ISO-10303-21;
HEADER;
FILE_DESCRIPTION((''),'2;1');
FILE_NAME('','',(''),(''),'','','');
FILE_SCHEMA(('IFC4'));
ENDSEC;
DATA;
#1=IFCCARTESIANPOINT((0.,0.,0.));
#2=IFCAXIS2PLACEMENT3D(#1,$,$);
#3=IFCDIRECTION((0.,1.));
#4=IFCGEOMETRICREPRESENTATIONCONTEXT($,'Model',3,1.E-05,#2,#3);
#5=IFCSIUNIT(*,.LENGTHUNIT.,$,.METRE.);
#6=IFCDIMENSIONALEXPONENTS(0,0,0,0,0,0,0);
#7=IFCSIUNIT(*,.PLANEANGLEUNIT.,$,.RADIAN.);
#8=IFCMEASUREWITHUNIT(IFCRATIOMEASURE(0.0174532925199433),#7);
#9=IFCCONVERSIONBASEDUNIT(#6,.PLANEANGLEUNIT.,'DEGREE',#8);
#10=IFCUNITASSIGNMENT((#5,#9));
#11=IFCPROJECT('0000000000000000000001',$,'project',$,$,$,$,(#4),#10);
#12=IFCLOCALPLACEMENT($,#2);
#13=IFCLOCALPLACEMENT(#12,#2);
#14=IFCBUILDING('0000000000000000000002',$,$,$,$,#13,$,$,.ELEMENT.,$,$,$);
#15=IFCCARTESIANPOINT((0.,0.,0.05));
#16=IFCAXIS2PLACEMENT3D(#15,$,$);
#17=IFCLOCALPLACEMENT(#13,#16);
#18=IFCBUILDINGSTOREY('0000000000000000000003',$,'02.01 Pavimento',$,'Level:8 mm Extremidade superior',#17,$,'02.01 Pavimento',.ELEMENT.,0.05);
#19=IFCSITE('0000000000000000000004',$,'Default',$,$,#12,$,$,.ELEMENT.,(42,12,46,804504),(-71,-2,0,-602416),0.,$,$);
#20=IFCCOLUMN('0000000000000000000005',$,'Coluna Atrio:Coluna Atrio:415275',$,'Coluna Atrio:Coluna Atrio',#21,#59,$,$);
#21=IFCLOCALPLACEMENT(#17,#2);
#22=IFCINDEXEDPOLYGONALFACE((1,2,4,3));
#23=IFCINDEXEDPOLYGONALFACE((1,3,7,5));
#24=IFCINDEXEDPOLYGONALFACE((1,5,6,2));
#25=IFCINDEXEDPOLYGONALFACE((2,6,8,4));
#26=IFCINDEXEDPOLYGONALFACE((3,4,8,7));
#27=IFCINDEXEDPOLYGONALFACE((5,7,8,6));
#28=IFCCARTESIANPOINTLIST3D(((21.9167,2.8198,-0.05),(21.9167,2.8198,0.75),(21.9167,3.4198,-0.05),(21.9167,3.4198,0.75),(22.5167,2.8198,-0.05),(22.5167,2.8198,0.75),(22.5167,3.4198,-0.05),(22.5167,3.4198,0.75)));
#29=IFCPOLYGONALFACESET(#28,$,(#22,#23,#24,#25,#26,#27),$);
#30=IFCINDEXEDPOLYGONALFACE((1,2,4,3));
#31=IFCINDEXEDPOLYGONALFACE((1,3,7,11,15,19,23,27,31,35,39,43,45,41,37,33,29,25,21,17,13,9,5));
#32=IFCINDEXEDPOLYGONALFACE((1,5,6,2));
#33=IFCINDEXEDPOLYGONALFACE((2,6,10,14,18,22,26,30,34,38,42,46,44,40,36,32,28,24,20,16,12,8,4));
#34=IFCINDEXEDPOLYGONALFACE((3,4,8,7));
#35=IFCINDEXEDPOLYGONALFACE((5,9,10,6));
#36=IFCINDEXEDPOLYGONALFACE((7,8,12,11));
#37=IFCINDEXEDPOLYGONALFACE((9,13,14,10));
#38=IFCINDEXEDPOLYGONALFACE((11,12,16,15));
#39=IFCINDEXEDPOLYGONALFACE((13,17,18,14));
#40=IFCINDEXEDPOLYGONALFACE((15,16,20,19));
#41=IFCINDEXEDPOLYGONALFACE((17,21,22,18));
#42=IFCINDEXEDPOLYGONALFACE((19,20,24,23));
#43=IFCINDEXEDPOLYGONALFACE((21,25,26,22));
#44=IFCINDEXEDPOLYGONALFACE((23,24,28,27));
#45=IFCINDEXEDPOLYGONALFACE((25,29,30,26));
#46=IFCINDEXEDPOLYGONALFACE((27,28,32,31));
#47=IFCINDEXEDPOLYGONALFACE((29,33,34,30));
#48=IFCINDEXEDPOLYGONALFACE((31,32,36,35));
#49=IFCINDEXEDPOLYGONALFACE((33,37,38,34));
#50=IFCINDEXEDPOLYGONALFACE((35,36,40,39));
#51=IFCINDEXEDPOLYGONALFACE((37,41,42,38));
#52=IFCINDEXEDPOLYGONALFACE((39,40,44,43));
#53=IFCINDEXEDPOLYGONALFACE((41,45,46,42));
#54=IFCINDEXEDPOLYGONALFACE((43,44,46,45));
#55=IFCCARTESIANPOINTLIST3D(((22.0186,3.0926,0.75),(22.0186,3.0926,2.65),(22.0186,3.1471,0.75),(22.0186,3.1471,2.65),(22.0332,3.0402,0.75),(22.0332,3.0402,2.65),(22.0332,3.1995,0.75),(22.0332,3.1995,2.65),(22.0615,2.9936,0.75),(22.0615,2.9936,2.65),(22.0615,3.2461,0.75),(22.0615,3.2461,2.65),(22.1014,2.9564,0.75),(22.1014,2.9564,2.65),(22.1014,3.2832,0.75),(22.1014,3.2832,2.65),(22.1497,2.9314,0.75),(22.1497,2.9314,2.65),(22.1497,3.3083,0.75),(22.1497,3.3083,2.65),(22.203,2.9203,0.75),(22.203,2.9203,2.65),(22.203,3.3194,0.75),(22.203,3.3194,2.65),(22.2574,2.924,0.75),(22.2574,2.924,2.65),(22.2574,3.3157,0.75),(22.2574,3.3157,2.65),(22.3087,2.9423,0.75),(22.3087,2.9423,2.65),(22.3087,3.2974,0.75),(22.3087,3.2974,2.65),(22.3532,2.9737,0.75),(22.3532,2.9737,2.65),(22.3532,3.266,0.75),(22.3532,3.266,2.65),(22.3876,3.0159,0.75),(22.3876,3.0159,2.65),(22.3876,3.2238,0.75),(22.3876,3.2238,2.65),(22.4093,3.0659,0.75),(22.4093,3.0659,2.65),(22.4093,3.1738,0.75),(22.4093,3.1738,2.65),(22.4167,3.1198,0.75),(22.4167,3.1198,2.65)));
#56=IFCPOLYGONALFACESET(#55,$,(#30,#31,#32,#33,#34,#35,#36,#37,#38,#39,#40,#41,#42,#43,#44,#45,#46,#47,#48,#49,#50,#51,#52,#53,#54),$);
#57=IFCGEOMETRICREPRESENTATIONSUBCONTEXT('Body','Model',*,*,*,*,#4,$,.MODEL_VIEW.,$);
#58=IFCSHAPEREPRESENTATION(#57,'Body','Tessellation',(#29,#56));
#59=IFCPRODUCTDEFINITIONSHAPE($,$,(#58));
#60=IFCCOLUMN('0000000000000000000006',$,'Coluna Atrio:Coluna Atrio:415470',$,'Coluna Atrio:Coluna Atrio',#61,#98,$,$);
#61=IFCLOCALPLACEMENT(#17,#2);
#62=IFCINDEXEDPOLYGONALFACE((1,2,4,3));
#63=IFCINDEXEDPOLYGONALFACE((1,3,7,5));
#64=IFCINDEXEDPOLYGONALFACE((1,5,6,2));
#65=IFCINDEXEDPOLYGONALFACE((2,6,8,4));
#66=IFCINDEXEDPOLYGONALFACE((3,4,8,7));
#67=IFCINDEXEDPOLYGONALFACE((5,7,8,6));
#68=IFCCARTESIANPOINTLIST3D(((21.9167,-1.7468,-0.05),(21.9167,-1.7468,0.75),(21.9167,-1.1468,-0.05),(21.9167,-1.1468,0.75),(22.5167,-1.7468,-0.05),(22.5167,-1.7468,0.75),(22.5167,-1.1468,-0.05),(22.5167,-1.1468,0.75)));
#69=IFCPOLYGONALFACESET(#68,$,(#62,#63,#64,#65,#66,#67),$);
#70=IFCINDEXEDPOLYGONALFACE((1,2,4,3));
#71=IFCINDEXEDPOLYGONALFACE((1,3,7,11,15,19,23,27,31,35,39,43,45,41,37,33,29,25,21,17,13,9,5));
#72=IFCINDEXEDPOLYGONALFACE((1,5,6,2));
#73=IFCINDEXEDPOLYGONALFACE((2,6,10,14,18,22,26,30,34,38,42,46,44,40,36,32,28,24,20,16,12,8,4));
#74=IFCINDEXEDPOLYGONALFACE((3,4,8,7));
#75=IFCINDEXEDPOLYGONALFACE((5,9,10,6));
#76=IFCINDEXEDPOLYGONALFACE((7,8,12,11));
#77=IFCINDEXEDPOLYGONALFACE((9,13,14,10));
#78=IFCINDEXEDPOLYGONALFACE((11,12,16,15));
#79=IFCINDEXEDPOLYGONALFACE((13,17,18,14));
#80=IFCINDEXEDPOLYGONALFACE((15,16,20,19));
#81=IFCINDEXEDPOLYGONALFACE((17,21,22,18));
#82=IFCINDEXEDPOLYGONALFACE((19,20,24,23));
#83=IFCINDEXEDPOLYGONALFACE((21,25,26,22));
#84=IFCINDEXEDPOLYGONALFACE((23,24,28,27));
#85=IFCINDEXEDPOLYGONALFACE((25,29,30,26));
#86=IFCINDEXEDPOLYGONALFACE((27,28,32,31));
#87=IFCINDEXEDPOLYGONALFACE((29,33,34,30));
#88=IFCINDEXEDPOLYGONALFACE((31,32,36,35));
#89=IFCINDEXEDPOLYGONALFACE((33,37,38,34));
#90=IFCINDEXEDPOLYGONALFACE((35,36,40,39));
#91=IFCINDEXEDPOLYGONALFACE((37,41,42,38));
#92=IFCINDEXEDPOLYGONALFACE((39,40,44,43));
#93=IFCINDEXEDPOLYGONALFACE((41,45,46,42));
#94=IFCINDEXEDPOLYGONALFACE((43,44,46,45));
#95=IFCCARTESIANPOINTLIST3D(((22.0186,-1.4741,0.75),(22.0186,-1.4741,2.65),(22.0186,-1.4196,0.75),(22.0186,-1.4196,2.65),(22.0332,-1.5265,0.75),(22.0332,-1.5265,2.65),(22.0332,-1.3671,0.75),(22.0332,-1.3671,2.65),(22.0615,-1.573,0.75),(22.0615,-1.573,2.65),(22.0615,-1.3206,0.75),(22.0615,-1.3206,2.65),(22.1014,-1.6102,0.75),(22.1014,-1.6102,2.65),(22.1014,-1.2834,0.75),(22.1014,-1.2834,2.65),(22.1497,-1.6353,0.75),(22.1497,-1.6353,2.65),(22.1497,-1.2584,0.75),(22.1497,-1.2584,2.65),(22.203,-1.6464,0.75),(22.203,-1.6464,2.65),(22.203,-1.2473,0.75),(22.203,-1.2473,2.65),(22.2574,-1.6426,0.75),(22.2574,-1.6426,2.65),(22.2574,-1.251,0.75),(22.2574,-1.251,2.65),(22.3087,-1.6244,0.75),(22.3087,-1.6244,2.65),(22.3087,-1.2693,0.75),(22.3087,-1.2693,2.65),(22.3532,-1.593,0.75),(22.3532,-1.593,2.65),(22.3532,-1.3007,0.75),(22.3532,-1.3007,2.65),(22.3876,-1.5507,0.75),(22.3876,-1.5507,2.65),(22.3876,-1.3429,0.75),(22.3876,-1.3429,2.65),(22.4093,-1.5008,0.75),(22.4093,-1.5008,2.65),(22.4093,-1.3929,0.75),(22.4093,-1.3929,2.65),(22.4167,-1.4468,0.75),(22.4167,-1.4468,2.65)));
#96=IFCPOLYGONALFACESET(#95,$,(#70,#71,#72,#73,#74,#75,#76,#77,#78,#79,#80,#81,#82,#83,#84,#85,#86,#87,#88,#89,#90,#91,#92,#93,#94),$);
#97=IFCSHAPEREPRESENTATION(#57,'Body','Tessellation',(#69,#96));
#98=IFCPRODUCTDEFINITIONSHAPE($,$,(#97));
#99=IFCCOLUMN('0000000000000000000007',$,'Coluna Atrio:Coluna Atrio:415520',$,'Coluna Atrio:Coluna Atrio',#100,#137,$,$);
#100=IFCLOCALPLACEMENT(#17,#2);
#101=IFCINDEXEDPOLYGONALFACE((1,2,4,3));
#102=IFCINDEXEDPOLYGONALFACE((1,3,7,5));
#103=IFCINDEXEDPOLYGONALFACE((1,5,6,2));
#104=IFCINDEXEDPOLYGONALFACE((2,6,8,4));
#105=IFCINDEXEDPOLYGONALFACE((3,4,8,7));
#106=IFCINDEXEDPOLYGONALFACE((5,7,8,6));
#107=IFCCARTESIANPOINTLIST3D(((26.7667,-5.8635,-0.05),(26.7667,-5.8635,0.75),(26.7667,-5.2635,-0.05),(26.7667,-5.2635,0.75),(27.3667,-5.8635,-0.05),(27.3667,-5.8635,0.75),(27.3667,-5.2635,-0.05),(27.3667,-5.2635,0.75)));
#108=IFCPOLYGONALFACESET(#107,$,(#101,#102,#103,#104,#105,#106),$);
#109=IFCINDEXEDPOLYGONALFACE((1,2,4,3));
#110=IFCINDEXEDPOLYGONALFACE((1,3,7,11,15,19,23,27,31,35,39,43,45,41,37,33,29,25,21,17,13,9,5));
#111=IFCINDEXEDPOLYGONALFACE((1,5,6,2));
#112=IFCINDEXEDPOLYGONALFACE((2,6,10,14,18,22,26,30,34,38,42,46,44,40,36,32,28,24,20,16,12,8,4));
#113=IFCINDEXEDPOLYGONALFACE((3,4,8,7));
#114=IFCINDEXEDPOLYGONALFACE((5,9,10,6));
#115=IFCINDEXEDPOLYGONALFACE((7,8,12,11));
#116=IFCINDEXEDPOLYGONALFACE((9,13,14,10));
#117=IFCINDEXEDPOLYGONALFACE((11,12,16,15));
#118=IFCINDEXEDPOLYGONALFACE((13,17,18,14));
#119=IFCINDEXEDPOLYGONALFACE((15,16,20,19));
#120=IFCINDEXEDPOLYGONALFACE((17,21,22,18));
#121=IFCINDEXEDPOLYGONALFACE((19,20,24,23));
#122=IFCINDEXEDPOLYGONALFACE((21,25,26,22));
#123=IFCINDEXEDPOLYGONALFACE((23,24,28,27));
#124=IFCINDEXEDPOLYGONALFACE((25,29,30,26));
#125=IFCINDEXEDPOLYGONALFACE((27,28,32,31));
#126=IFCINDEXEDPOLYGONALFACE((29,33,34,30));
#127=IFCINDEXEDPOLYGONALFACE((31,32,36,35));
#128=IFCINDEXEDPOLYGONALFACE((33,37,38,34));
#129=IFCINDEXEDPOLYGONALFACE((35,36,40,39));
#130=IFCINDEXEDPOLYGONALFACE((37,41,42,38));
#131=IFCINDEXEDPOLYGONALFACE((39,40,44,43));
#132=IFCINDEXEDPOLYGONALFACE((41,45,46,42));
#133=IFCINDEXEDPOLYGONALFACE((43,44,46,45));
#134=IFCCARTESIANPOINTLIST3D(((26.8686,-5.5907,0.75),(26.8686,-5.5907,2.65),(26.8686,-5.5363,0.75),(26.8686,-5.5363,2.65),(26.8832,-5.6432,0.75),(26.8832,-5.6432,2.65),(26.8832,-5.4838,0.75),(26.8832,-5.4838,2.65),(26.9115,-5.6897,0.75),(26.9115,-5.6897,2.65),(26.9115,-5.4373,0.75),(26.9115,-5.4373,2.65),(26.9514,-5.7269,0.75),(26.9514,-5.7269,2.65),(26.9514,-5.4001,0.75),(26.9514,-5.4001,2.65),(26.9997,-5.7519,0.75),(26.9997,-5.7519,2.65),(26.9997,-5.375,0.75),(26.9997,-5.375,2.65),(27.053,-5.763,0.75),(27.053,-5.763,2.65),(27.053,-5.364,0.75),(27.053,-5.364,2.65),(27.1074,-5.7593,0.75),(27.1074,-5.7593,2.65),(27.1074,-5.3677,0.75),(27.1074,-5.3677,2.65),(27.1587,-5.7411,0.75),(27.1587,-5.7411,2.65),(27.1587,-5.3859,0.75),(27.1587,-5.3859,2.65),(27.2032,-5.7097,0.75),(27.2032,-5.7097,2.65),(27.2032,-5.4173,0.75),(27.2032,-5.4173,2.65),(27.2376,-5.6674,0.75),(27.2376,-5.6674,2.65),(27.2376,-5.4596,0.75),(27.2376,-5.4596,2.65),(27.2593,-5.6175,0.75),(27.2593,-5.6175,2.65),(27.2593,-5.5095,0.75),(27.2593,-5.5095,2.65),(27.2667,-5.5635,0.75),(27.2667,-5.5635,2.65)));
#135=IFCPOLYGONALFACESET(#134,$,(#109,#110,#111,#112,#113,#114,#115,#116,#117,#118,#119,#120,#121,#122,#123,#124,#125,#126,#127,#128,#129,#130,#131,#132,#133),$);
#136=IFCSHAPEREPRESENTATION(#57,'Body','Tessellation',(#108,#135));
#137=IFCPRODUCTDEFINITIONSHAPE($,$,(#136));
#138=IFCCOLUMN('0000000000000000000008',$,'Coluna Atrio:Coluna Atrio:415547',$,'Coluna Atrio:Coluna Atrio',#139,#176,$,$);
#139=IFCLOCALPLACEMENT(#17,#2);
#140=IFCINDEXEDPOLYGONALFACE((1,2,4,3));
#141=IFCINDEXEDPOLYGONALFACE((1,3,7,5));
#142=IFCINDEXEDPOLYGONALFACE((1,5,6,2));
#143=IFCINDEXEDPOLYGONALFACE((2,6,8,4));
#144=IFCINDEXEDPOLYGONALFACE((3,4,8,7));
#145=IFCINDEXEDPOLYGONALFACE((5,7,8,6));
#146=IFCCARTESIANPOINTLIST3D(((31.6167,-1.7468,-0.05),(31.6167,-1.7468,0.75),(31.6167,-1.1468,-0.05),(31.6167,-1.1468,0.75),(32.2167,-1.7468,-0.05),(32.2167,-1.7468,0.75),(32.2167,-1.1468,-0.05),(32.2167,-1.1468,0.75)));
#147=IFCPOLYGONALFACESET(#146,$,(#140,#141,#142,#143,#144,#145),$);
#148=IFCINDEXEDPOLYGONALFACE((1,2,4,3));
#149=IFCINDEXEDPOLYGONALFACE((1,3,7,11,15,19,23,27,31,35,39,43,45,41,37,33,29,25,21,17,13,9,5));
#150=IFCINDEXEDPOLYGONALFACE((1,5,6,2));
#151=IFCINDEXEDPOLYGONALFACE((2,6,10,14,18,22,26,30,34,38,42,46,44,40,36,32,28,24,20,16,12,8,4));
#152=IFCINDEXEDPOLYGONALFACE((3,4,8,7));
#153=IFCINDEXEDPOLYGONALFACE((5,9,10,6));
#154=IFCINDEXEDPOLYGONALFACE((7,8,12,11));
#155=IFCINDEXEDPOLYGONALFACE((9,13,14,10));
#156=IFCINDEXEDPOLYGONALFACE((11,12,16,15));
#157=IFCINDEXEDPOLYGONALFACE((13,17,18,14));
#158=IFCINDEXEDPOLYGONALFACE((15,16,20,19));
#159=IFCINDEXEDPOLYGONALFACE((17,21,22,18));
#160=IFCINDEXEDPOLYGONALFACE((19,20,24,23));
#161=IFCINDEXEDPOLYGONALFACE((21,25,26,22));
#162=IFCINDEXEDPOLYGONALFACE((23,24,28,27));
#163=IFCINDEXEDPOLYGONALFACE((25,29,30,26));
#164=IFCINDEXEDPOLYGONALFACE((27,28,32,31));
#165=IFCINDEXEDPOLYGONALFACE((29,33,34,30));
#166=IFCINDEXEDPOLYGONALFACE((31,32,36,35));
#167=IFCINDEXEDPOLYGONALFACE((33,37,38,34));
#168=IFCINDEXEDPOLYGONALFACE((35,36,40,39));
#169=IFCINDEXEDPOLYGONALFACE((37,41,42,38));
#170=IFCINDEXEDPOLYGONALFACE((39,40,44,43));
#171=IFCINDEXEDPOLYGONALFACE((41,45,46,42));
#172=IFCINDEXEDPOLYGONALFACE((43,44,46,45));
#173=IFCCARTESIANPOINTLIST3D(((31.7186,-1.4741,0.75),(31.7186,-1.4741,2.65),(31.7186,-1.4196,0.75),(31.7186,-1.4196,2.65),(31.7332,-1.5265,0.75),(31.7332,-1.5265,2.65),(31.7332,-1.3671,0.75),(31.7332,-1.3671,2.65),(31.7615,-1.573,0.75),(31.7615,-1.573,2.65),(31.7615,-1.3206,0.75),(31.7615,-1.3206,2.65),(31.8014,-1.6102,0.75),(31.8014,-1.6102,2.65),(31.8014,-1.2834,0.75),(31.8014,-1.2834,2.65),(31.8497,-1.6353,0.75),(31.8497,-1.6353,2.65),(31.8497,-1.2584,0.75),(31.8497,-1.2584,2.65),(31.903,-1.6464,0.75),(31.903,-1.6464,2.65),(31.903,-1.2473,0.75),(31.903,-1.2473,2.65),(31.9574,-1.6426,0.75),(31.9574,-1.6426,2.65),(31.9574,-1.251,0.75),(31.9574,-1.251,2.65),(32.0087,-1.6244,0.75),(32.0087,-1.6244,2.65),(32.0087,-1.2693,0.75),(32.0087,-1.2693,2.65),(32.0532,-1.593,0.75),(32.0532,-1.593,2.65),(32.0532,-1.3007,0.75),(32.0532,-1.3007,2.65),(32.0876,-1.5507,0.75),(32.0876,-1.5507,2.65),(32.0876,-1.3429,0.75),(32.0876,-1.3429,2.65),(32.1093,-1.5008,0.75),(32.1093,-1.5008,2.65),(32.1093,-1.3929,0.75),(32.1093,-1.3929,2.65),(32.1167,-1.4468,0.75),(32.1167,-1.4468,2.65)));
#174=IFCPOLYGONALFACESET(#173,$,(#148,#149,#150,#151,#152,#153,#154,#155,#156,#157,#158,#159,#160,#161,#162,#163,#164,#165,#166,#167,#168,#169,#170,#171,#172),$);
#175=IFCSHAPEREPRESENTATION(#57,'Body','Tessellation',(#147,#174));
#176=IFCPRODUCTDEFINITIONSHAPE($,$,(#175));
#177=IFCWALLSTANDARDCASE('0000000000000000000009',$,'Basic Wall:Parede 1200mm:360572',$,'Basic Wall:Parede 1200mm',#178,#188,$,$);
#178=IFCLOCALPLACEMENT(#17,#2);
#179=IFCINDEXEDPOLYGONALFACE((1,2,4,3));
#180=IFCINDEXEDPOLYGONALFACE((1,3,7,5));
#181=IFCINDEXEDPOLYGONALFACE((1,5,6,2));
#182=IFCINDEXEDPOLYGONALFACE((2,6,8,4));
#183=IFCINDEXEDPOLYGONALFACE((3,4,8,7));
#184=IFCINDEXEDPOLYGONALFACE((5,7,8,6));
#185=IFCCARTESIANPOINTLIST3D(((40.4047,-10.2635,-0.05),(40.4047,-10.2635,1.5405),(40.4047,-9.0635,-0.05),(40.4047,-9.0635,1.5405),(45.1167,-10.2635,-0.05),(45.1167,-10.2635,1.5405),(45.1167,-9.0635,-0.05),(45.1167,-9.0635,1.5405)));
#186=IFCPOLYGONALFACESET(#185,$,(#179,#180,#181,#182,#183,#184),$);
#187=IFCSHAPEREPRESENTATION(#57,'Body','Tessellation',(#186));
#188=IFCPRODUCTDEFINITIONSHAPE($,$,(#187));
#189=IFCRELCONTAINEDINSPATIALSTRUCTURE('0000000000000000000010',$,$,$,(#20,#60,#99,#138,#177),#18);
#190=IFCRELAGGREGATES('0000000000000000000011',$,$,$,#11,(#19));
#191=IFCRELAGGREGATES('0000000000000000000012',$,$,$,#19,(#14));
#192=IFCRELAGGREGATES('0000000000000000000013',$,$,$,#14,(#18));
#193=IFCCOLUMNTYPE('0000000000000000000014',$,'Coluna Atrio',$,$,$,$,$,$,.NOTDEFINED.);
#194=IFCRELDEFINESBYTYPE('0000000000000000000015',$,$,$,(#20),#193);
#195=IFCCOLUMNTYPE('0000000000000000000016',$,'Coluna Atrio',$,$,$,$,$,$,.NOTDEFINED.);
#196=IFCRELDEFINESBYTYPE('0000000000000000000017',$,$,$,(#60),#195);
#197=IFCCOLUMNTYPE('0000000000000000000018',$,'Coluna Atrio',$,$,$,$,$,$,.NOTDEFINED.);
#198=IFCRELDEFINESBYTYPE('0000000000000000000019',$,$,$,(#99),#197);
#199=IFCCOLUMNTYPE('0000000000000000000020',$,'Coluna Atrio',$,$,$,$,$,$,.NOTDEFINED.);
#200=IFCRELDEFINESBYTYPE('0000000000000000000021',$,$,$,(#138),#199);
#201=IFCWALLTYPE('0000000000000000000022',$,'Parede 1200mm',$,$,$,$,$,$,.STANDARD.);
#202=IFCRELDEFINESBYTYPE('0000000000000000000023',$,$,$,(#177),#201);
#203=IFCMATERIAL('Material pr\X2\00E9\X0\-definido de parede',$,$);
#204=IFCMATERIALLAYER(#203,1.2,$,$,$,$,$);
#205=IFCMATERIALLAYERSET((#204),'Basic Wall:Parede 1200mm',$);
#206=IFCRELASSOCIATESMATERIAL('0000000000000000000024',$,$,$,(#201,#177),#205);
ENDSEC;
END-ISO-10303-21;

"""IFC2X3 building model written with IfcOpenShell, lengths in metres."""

from ifc_helpers import new_model, entity, si_unit, converted_unit, direction, frame, frame_2d, origin, origin_2d_with_axis, place, context, subcontext, project, spatial, rectangle, circle, extrude, clip, halfspace, source, transform, mapped, material, layer, layer_set, layer_usage, type_object, type_shapes, element, save


model = new_model("IFC2X3")

# Units and contexts
model_context = context("Model", 3, precision=1e-05, world=origin(), true_north=direction((0.0, 1.0)))
body_context = subcontext(model_context, "Body", "Model", "MODEL_VIEW")
ifc_project = project(units=[si_unit("LENGTHUNIT", "METRE"), converted_unit("PLANEANGLEUNIT", "DEGREE", entity("IfcRatioMeasure", 0.0174532925199433), si_unit("PLANEANGLEUNIT", "RADIAN"), dimensions=[0, 0, 0, 0, 0, 0, 0])], contexts=[model_context])

# Site, building, storey
site_placement = place(None, origin())
site = spatial("IfcSite", under=ifc_project, at=site_placement, Name="Default", CompositionType="ELEMENT", RefLatitude=(42, 12, 46, 804504), RefLongitude=(-71, -2, 0, -602416), RefElevation=0.0)
building_placement = place(site_placement, origin())
building = spatial("IfcBuilding", under=site, at=building_placement, CompositionType="ELEMENT")
storey_placement = place(building_placement, frame((0.0, 0.0, 0.05)))
storey = spatial("IfcBuildingStorey", under=building, at=storey_placement, Name="02.01 Pavimento", ObjectType="Level:8 mm Extremidade superior", LongName="02.01 Pavimento", CompositionType="ELEMENT", Elevation=0.05)

# Columns
column_type_1 = type_object("IfcColumnType", Name="Coluna Atrio", PredefinedType="NOTDEFINED")
shared_shape_1 = source(origin(), body_context, "Body", "SweptSolid", [
    extrude(rectangle(XDim=0.6, YDim=0.6, at=origin_2d_with_axis()), frame((0.0, 0.0, 0.0), z_axis=(0.0, 0.0, 1.0), x_axis=(0.0, -1.0, 0.0)), (0.0, 0.0, 1.0), 0.8),
    extrude(circle(Radius=0.2, at=frame_2d((0.0, 0.0), x_axis=(1.0, 0.0))), frame((0.0, 0.0, 0.8)), (0.0, 0.0, 1.0), 1.9),
])
type_shapes(column_type_1, [shared_shape_1])
column_1_placement = place(storey_placement, frame((22.2167, 3.1198, -0.05)))
element("IfcColumn", 1, at=column_1_placement, inside=storey, type_object=column_type_1, Name="Coluna Atrio:Coluna Atrio:415275", ObjectType="Coluna Atrio:Coluna Atrio", context=body_context, shape_type="MappedRepresentation", body=[
    mapped(shared_shape_1, transform((0.0, 0.0, 0.0), scale=1.0)),
])
column_type_2 = type_object("IfcColumnType", Name="Coluna Atrio", PredefinedType="NOTDEFINED")
shared_shape_2 = source(origin(), body_context, "Body", "SweptSolid", [
    extrude(rectangle(XDim=0.6, YDim=0.6, at=origin_2d_with_axis()), frame((0.0, 0.0, 0.0), z_axis=(0.0, 0.0, 1.0), x_axis=(0.0, -1.0, 0.0)), (0.0, 0.0, 1.0), 0.8),
    extrude(circle(Radius=0.2, at=frame_2d((0.0, 0.0), x_axis=(1.0, 0.0))), frame((0.0, 0.0, 0.8)), (0.0, 0.0, 1.0), 1.9),
])
type_shapes(column_type_2, [shared_shape_2])
column_2_placement = place(storey_placement, frame((22.2167, -1.4468, -0.05)))
element("IfcColumn", 2, at=column_2_placement, inside=storey, type_object=column_type_2, Name="Coluna Atrio:Coluna Atrio:415470", ObjectType="Coluna Atrio:Coluna Atrio", context=body_context, shape_type="MappedRepresentation", body=[
    mapped(shared_shape_2, transform((0.0, 0.0, 0.0), scale=1.0)),
])
column_type_3 = type_object("IfcColumnType", Name="Coluna Atrio", PredefinedType="NOTDEFINED")
shared_shape_3 = source(origin(), body_context, "Body", "SweptSolid", [
    extrude(rectangle(XDim=0.6, YDim=0.6, at=origin_2d_with_axis()), frame((0.0, 0.0, 0.0), z_axis=(0.0, 0.0, 1.0), x_axis=(0.0, -1.0, 0.0)), (0.0, 0.0, 1.0), 0.8),
    extrude(circle(Radius=0.2, at=frame_2d((0.0, 0.0), x_axis=(1.0, 0.0))), frame((0.0, 0.0, 0.8)), (0.0, 0.0, 1.0), 1.9),
])
type_shapes(column_type_3, [shared_shape_3])
column_3_placement = place(storey_placement, frame((27.0667, -5.5635, -0.05)))
element("IfcColumn", 3, at=column_3_placement, inside=storey, type_object=column_type_3, Name="Coluna Atrio:Coluna Atrio:415520", ObjectType="Coluna Atrio:Coluna Atrio", context=body_context, shape_type="MappedRepresentation", body=[
    mapped(shared_shape_3, transform((0.0, 0.0, 0.0), scale=1.0)),
])
column_type_4 = type_object("IfcColumnType", Name="Coluna Atrio", PredefinedType="NOTDEFINED")
shared_shape_4 = source(origin(), body_context, "Body", "SweptSolid", [
    extrude(rectangle(XDim=0.6, YDim=0.6, at=origin_2d_with_axis()), frame((0.0, 0.0, 0.0), z_axis=(0.0, 0.0, 1.0), x_axis=(0.0, -1.0, 0.0)), (0.0, 0.0, 1.0), 0.8),
    extrude(circle(Radius=0.2, at=frame_2d((0.0, 0.0), x_axis=(1.0, 0.0))), frame((0.0, 0.0, 0.8)), (0.0, 0.0, 1.0), 1.9),
])
type_shapes(column_type_4, [shared_shape_4])
column_4_placement = place(storey_placement, frame((31.9167, -1.4468, -0.05)))
element("IfcColumn", 4, at=column_4_placement, inside=storey, type_object=column_type_4, Name="Coluna Atrio:Coluna Atrio:415547", ObjectType="Coluna Atrio:Coluna Atrio", context=body_context, shape_type="MappedRepresentation", body=[
    mapped(shared_shape_4, transform((0.0, 0.0, 0.0), scale=1.0)),
])

# Wall
ifc_material_1 = material(Name="Material pré-definido de parede")
ifc_layer_1 = layer(ifc_material_1, 1.2)
ifc_layer_set_1 = layer_set([ifc_layer_1], Name="Basic Wall:Parede 1200mm")
ifc_layer_usage_1 = layer_usage(ifc_layer_set_1, "AXIS2", "POSITIVE", -0.6)
wall_type_1 = type_object("IfcWallType", Name="Parede 1200mm", PredefinedType="STANDARD", material=ifc_layer_set_1)
wall_1_placement = place(storey_placement, frame((45.1167, -9.6635, -0.05), z_axis=(0.0, 0.0, 1.0), x_axis=(-1.0, 0.0, 0.0)))
element("IfcWallStandardCase", 5, at=wall_1_placement, inside=storey, type_object=wall_type_1, material=ifc_layer_usage_1, Name="Basic Wall:Parede 1200mm:360572", ObjectType="Basic Wall:Parede 1200mm", context=body_context, shape_type="Clipping", body=[
    clip(extrude(rectangle(XDim=4.712, YDim=1.2, at=frame_2d((2.356, 0.0), x_axis=(-1.0, 0.0))), origin(), (0.0, 0.0, 1.0), 1.5905), halfspace(frame((0.0, 0.0, -0.05)), True)),
])

save(model, "model.ifc")
